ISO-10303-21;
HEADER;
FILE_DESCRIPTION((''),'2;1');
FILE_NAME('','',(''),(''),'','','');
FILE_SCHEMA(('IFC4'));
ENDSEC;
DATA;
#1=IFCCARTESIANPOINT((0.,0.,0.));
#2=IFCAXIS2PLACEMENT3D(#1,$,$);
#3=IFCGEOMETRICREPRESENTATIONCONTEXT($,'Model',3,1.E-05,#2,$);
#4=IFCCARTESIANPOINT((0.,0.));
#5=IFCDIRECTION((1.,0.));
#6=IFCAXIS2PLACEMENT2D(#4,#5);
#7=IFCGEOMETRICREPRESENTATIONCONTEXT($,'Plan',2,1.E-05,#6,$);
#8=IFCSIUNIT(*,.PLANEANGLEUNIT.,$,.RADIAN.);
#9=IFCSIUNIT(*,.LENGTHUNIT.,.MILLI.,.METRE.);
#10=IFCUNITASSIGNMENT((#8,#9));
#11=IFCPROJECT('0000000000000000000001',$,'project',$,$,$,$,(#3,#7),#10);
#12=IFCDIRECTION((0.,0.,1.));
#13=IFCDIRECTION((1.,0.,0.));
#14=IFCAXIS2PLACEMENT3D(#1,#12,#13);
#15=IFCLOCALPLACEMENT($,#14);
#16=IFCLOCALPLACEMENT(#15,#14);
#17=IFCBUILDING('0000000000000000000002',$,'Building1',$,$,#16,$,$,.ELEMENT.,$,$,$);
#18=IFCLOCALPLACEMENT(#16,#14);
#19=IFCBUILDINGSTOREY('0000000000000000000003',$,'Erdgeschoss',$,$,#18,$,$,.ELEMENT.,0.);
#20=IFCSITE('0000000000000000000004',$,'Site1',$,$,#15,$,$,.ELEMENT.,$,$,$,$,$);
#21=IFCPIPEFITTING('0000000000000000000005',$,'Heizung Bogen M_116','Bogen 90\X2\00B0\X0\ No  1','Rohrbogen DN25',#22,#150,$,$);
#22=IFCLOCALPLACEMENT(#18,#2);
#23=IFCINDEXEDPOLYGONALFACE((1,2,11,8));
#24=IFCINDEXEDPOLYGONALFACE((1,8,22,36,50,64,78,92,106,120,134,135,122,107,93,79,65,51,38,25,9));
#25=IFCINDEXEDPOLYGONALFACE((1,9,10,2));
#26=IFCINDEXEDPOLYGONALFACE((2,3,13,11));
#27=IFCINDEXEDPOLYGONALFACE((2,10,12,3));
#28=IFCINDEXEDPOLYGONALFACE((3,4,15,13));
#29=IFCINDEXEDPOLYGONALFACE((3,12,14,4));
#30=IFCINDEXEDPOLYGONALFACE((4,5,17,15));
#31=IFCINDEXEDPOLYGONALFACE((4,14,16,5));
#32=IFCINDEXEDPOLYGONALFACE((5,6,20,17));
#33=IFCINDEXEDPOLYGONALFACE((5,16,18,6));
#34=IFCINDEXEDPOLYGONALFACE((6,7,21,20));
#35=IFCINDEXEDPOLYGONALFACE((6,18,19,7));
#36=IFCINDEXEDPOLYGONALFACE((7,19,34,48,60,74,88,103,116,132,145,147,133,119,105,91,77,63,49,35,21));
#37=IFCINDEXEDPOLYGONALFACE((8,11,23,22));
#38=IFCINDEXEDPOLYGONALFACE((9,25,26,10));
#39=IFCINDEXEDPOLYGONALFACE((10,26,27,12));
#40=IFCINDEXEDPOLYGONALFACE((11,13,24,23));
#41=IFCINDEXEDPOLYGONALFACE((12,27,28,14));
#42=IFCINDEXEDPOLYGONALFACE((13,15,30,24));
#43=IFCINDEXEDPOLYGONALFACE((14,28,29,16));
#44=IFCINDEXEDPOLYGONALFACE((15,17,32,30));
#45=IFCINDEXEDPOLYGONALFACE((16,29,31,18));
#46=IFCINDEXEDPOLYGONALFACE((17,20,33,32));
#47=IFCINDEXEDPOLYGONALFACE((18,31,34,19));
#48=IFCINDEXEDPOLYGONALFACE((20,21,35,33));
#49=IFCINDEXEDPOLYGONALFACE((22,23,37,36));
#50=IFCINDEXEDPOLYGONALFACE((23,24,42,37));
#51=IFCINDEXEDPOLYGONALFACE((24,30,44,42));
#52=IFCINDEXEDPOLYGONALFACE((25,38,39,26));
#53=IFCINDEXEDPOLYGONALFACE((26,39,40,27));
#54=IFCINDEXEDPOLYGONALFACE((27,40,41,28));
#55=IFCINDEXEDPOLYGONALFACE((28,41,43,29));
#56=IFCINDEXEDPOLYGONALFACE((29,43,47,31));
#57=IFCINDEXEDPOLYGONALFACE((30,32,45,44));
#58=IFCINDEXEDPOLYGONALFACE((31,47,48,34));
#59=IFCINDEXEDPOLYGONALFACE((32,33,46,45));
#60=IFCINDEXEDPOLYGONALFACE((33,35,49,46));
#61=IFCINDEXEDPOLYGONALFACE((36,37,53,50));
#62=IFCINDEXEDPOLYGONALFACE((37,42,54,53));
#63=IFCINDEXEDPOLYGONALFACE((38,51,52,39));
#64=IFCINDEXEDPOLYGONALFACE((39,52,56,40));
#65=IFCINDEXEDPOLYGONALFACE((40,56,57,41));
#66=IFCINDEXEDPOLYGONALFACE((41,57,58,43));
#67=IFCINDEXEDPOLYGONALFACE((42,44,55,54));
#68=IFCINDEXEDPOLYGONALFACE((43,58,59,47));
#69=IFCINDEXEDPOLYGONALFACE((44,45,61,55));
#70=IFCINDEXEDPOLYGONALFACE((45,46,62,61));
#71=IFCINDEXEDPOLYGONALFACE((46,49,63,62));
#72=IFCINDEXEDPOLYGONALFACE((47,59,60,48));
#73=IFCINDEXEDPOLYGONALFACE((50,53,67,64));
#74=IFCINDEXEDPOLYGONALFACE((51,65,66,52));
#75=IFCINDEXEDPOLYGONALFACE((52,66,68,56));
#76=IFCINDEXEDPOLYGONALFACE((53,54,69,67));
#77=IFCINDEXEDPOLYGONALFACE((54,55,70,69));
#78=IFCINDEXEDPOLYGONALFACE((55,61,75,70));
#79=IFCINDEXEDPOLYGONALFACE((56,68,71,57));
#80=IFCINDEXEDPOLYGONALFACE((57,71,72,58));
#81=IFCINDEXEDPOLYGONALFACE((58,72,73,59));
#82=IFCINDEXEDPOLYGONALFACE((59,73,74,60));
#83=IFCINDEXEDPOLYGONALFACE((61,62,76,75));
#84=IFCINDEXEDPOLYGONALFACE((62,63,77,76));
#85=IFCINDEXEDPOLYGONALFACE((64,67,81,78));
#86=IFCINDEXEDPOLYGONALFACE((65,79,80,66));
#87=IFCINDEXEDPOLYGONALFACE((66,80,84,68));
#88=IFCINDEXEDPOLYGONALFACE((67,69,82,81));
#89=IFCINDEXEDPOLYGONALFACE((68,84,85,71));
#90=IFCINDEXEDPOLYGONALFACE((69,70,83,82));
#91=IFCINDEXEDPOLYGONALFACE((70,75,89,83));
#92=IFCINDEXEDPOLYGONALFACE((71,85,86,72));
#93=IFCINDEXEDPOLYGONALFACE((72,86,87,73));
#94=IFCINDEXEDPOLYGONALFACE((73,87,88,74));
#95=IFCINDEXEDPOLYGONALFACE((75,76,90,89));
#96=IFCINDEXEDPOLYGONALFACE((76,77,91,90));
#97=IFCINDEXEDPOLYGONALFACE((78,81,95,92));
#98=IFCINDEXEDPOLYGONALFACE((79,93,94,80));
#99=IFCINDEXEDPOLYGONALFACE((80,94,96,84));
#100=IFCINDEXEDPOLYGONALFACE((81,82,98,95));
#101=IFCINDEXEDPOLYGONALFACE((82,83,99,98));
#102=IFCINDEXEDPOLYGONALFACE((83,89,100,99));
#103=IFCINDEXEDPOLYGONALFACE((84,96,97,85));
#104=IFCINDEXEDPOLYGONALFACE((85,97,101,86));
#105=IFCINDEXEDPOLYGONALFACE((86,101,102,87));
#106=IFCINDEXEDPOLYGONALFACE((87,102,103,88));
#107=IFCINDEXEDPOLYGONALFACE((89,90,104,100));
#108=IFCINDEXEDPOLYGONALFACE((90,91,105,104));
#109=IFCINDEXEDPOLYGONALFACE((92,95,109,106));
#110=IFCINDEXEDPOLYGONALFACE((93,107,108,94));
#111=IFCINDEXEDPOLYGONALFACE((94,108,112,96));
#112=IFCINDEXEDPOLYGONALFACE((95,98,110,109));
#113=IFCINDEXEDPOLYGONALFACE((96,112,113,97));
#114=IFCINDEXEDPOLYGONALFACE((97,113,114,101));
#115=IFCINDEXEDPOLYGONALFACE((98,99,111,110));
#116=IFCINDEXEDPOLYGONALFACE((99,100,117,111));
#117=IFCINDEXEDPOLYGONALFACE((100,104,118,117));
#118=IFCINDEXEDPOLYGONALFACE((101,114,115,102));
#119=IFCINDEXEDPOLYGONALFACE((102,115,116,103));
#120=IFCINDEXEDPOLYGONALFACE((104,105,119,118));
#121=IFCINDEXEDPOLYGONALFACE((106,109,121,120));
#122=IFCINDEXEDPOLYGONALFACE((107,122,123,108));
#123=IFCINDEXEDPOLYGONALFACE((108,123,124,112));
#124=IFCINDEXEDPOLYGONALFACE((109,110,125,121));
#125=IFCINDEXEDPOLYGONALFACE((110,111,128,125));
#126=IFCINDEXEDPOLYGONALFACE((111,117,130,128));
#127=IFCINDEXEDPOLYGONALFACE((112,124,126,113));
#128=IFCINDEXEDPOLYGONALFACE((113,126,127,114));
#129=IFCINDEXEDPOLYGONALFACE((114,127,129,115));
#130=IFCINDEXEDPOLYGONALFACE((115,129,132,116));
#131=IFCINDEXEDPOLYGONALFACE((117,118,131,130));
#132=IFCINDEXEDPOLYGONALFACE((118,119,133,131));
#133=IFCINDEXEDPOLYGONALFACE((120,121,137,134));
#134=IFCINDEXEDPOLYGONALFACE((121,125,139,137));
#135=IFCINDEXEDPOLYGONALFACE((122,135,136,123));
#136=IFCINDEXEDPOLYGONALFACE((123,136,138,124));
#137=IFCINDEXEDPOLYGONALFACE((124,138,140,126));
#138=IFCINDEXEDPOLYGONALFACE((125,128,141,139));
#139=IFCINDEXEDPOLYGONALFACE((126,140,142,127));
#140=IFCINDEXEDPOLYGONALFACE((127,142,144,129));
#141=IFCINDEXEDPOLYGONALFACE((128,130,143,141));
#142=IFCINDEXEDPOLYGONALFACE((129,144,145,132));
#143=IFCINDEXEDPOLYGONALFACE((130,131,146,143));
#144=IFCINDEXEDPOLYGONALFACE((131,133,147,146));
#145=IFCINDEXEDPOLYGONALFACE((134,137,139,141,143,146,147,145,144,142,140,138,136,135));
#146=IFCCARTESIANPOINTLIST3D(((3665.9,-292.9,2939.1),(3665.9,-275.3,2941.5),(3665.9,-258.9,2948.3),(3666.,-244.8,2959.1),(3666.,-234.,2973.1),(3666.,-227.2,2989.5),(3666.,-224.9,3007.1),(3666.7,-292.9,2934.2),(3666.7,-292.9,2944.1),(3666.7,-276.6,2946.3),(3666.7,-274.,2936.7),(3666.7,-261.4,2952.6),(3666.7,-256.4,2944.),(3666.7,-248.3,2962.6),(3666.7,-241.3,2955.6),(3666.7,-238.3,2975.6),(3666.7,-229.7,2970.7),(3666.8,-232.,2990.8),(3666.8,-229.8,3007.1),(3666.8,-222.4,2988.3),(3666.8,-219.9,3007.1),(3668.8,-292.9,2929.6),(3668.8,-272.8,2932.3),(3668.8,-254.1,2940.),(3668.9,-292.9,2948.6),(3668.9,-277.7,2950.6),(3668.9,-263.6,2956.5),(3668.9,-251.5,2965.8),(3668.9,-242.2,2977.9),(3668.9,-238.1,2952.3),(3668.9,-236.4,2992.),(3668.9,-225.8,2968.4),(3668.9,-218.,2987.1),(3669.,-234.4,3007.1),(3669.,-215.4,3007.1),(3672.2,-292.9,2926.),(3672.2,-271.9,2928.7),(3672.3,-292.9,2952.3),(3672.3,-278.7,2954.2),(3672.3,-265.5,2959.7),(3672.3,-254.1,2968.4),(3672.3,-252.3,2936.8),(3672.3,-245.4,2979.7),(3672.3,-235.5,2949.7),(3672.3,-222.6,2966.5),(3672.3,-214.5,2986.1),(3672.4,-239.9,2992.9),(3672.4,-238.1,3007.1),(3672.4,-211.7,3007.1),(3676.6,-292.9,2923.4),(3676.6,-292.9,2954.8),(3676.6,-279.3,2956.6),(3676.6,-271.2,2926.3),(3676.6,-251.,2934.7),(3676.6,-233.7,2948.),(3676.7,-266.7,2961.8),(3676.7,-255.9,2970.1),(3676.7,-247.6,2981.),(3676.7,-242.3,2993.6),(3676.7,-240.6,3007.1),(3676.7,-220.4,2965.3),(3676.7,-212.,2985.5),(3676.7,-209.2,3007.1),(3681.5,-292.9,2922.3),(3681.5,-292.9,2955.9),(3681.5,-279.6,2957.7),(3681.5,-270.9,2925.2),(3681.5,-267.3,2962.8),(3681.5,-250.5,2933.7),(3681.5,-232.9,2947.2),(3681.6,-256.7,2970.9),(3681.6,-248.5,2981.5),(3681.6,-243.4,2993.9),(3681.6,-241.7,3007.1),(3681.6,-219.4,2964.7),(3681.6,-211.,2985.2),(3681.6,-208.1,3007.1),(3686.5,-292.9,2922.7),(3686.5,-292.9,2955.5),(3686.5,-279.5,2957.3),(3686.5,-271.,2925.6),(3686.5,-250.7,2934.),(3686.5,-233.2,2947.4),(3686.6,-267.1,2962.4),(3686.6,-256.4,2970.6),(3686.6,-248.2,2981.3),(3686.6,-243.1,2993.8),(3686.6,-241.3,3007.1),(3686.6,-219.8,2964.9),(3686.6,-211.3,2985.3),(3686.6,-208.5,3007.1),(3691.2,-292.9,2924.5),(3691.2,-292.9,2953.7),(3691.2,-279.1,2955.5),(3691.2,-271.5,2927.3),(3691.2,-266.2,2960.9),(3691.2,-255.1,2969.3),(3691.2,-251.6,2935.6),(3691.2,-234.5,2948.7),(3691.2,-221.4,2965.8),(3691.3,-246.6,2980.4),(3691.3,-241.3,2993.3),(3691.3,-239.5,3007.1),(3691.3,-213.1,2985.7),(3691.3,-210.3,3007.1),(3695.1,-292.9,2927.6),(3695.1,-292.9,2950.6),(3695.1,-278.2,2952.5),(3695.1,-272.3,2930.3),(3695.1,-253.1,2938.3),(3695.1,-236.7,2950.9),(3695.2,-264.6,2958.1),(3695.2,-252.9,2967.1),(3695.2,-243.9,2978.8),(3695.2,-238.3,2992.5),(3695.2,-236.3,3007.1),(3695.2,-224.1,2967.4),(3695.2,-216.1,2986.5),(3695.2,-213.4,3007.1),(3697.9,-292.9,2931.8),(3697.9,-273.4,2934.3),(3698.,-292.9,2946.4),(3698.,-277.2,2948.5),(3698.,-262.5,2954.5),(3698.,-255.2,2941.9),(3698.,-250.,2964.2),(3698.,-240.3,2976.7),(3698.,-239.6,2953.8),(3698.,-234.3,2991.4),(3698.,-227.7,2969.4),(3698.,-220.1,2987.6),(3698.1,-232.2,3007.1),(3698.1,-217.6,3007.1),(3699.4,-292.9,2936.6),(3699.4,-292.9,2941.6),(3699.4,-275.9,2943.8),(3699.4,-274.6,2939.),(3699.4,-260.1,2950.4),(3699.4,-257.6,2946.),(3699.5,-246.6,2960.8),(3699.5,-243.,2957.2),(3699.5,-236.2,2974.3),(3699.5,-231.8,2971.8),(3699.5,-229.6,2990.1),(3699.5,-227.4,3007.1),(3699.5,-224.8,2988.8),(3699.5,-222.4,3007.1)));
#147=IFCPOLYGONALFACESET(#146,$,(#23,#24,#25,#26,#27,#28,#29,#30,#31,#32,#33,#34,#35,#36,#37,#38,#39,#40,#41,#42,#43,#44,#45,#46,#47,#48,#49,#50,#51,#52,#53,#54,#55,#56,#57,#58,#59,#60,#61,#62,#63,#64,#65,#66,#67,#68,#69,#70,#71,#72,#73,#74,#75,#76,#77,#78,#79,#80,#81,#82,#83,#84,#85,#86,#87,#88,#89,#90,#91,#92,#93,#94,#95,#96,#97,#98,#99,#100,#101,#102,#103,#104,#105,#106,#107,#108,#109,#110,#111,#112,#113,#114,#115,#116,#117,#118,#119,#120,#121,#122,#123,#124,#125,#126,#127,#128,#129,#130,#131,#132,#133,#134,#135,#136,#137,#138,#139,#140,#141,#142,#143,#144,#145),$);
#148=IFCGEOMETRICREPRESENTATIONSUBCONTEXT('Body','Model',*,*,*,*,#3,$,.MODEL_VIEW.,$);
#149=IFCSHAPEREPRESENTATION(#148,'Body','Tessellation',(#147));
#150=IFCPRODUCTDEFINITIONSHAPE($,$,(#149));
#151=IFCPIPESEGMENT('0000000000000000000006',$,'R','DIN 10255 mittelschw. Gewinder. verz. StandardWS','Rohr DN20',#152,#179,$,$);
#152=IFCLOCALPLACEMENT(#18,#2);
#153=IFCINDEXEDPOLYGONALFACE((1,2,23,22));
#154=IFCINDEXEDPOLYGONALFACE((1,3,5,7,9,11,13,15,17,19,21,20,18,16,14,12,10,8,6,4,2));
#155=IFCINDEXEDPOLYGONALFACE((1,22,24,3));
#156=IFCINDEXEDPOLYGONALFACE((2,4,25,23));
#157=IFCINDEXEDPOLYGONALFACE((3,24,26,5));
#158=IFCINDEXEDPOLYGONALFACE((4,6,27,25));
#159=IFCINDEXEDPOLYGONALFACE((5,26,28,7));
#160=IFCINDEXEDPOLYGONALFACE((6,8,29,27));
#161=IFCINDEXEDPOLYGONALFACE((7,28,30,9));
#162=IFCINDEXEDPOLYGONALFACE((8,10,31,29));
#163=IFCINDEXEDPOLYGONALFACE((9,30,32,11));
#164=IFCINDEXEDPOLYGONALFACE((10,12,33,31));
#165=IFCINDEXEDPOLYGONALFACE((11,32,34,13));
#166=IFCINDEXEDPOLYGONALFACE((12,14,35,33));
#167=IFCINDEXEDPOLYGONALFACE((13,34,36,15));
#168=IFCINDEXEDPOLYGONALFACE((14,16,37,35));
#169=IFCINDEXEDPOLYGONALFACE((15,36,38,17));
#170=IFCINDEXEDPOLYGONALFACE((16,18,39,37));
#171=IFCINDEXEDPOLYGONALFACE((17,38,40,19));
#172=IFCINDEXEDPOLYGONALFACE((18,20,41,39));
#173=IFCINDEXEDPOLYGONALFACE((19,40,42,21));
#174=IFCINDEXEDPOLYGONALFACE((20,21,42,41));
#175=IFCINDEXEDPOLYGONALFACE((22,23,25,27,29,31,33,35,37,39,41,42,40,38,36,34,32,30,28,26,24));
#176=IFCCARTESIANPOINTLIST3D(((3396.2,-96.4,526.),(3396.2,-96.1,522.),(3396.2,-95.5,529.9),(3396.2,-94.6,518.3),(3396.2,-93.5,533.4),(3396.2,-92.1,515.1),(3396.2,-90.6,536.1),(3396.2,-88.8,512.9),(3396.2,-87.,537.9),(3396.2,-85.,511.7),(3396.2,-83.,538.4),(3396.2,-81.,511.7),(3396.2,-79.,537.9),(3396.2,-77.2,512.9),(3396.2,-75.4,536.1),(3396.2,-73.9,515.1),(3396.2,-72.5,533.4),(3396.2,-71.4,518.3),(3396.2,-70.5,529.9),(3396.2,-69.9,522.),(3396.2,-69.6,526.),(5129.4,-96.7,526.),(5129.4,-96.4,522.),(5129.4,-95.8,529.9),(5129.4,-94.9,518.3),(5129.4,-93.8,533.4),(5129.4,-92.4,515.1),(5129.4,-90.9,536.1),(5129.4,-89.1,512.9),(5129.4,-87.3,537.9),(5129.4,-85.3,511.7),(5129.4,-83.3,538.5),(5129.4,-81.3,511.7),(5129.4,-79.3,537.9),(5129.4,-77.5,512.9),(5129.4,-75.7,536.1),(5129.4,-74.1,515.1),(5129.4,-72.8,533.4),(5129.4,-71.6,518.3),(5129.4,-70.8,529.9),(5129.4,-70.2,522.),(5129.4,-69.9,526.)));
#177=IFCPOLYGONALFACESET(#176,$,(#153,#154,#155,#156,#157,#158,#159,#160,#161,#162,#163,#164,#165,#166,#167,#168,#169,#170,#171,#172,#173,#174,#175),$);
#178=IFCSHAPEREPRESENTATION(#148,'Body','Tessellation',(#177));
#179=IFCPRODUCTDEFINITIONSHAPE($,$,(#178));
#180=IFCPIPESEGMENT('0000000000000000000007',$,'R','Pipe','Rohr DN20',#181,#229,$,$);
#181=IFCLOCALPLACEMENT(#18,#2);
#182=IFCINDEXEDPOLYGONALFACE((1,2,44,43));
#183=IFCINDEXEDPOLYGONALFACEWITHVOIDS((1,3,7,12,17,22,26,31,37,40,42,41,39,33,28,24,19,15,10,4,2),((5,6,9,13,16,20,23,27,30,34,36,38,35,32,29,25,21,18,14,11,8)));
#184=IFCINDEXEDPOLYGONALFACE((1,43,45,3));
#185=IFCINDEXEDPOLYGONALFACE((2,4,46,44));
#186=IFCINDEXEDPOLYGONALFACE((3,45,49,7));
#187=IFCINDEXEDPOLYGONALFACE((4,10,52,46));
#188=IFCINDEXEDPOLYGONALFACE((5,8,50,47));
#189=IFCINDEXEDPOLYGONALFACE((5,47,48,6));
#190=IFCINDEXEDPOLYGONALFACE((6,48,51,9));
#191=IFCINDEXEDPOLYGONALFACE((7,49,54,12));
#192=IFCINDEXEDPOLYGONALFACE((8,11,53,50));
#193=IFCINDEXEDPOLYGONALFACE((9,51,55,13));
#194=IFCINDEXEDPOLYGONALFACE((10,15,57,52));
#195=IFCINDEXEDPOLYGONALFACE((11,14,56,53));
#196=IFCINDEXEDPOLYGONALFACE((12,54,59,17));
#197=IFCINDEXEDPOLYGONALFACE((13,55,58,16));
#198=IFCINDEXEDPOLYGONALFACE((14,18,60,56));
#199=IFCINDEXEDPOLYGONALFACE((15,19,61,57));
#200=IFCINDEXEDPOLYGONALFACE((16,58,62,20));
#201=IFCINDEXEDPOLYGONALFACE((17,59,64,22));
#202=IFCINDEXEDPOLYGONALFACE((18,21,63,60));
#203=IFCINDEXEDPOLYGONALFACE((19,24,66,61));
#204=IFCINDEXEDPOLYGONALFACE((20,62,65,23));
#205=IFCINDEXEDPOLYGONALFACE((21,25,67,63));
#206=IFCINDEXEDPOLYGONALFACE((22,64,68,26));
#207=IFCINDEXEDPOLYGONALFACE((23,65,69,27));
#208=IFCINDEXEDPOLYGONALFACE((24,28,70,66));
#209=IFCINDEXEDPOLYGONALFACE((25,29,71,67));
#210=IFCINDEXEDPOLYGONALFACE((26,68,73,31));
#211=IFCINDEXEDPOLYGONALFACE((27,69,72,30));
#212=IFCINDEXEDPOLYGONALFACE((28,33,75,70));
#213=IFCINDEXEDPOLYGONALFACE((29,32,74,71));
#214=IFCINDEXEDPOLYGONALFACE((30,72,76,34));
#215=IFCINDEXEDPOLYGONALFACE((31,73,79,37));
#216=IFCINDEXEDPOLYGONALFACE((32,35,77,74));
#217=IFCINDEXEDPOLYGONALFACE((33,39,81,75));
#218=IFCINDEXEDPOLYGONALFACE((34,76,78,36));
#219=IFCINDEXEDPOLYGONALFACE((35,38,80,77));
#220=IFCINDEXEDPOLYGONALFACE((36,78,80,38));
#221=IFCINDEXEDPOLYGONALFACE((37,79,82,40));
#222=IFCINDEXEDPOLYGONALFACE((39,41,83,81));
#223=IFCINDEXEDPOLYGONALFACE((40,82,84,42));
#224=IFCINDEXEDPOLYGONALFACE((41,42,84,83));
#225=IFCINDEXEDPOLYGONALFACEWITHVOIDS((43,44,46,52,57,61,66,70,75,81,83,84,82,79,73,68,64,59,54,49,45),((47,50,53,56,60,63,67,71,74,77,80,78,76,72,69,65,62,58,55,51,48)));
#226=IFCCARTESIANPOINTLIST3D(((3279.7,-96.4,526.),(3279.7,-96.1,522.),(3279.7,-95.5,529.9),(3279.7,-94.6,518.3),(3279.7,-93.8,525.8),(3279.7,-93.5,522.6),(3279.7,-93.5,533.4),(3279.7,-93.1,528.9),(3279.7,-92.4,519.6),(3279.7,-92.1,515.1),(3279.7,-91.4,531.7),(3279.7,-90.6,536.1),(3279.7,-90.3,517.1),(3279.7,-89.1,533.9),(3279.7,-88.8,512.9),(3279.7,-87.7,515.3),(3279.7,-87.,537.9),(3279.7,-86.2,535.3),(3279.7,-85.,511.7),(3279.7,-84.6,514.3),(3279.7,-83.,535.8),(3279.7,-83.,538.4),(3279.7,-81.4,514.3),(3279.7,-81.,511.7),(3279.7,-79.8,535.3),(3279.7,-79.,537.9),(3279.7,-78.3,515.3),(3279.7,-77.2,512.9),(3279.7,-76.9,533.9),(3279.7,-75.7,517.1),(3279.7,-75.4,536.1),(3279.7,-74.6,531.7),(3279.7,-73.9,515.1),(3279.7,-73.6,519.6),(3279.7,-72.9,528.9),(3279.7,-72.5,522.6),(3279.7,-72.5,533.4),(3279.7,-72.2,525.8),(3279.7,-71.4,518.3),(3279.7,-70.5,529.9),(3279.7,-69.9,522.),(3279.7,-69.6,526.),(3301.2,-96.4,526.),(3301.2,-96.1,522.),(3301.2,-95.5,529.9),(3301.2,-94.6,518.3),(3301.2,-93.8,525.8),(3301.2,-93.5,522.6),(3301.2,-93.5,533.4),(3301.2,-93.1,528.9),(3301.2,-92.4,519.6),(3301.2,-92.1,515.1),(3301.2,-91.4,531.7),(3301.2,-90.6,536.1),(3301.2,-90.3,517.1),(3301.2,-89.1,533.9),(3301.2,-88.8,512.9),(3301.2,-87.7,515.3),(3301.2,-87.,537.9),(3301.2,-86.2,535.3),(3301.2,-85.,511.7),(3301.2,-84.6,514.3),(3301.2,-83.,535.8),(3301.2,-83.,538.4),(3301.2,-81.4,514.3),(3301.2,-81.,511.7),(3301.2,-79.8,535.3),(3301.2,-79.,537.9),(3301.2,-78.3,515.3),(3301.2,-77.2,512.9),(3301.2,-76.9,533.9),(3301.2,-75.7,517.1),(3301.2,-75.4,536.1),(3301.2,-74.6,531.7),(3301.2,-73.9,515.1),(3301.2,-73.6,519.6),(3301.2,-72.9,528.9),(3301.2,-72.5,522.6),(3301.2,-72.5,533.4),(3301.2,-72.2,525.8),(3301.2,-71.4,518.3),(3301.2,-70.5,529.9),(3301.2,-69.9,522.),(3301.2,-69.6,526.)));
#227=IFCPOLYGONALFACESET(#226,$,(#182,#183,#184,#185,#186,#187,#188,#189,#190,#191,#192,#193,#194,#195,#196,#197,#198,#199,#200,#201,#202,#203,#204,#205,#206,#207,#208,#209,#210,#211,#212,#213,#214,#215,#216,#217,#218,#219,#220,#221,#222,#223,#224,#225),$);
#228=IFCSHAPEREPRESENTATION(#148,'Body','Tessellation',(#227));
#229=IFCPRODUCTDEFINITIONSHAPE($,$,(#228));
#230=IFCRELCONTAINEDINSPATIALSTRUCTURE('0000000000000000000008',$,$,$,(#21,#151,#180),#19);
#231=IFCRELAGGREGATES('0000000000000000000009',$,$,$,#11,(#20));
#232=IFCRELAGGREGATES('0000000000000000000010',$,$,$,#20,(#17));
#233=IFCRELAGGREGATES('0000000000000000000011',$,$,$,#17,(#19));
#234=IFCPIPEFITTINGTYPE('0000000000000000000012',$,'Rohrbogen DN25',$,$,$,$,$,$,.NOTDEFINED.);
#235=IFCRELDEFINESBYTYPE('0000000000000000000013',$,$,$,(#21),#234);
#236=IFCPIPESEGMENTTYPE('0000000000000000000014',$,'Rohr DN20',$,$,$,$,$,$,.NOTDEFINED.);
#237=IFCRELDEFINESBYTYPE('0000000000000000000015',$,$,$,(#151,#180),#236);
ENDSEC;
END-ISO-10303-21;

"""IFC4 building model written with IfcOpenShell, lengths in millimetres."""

from ifc_helpers import new_model, entity, si_unit, frame, origin, origin_with_axes, origin_2d_with_axis, place, context, subcontext, project, spatial, circle, hollow_circle, extrude, source, transform, mapped, type_object, element, save


model = new_model("IFC4")

# Units and contexts
model_context = context("Model", 3, precision=1e-05, world=origin())
plan_context = context("Plan", 2, precision=1e-05, world=origin_2d_with_axis())
body_context = subcontext(model_context, "Body", "Model", "MODEL_VIEW")
ifc_project = project(units=[si_unit("PLANEANGLEUNIT", "RADIAN"), si_unit("LENGTHUNIT", "METRE", prefix="MILLI")], contexts=[model_context, plan_context])

# Site, building, storey
site_placement = place(None, origin_with_axes())
site = spatial("IfcSite", under=ifc_project, at=site_placement, Name="Site1", CompositionType="ELEMENT")
building_placement = place(site_placement, origin_with_axes())
building = spatial("IfcBuilding", under=site, at=building_placement, Name="Building1", CompositionType="ELEMENT")
storey_placement = place(building_placement, origin_with_axes())
storey = spatial("IfcBuildingStorey", under=building, at=storey_placement, Name="Erdgeschoss", CompositionType="ELEMENT", Elevation=0.0)

# Pipe fitting
pipe_fitting_type_1 = type_object("IfcPipeFittingType", Name="Rohrbogen DN25", PredefinedType="NOTDEFINED")
shared_shape_1 = source(origin_with_axes(), body_context, "Body", "SolidModel", [
    entity("IfcRevolvedAreaSolid", entity("IfcCircleProfileDef", "AREA", None, entity("IfcAxis2Placement2D", entity("IfcCartesianPoint", [0.0, 0.0]), entity("IfcDirection", [1.0, 0.0])), 16.9), entity("IfcAxis2Placement3D", entity("IfcCartesianPoint", [-42.4, 0.0, -25.6]), entity("IfcDirection", [1.0, 0.0, 0.0]), entity("IfcDirection", [0.0, 0.999999, 0.00173])), entity("IfcAxis1Placement", entity("IfcCartesianPoint", [0.0, 68.0, 0.0]), entity("IfcDirection", [-1.0, 0.0, 0.0])), 1.570796),
])
pipe_fitting_1_placement = place(storey_placement, frame((3682.8, -250.5, 2964.7), z_axis=(0.0, 0.0, 1.0), x_axis=(1.0, 0.0, 0.0)))
element("IfcPipeFitting", 1, at=pipe_fitting_1_placement, inside=storey, type_object=pipe_fitting_type_1, Name="Heizung Bogen M_116", Description="Bogen 90° No  1", ObjectType="Rohrbogen DN25", context=body_context, shape_type="MappedRepresentation", body=[
    mapped(shared_shape_1, transform((0.0, 0.0, 0.0), x_axis=(0.0, 1.0, 0.0), y_axis=(-1.0, 0.0, 0.0), z_axis=(0.0, 0.0, 1.0), scale=1.0)),
])

# Pipe segments
pipe_segment_type_1 = type_object("IfcPipeSegmentType", Name="Rohr DN20", PredefinedType="NOTDEFINED")
pipe_segment_1_placement = place(storey_placement, frame((4262.8, -83.3, 525.0), z_axis=(0.0, 0.0, 1.0), x_axis=(1.0, 0.0, 0.0)))
element("IfcPipeSegment", 2, at=pipe_segment_1_placement, inside=storey, type_object=pipe_segment_type_1, Name="R", Description="DIN 10255 mittelschw. Gewinder. verz. StandardWS", ObjectType="Rohr DN20", context=body_context, shape_type="SolidModel", body=[
    extrude(circle(Radius=13.4, at=origin_2d_with_axis()), frame((866.6, 0.0, 0.0), z_axis=(-1.0, 0.000169, -0.000005), x_axis=(0.0, 0.0, 1.0)), (0.0, 0.0, 1.0), 1733.1),
])
pipe_segment_2_placement = place(storey_placement, frame((3290.5, -82.8, 525.0), z_axis=(0.0, 0.0, 1.0), x_axis=(1.0, 0.0, 0.0)))
element("IfcPipeSegment", 3, at=pipe_segment_2_placement, inside=storey, type_object=pipe_segment_type_1, Name="R", Description="Pipe", ObjectType="Rohr DN20", context=body_context, shape_type="SolidModel", body=[
    extrude(hollow_circle(Radius=13.4, WallThickness=2.6, at=origin_2d_with_axis()), frame((-10.8, -0.1, 0.0), z_axis=(1.0, 0.0, 0.000043), x_axis=(0.0, 0.0, 1.0)), (0.0, 0.0, 1.0), 21.5),
])

save(model, "model.ifc")
